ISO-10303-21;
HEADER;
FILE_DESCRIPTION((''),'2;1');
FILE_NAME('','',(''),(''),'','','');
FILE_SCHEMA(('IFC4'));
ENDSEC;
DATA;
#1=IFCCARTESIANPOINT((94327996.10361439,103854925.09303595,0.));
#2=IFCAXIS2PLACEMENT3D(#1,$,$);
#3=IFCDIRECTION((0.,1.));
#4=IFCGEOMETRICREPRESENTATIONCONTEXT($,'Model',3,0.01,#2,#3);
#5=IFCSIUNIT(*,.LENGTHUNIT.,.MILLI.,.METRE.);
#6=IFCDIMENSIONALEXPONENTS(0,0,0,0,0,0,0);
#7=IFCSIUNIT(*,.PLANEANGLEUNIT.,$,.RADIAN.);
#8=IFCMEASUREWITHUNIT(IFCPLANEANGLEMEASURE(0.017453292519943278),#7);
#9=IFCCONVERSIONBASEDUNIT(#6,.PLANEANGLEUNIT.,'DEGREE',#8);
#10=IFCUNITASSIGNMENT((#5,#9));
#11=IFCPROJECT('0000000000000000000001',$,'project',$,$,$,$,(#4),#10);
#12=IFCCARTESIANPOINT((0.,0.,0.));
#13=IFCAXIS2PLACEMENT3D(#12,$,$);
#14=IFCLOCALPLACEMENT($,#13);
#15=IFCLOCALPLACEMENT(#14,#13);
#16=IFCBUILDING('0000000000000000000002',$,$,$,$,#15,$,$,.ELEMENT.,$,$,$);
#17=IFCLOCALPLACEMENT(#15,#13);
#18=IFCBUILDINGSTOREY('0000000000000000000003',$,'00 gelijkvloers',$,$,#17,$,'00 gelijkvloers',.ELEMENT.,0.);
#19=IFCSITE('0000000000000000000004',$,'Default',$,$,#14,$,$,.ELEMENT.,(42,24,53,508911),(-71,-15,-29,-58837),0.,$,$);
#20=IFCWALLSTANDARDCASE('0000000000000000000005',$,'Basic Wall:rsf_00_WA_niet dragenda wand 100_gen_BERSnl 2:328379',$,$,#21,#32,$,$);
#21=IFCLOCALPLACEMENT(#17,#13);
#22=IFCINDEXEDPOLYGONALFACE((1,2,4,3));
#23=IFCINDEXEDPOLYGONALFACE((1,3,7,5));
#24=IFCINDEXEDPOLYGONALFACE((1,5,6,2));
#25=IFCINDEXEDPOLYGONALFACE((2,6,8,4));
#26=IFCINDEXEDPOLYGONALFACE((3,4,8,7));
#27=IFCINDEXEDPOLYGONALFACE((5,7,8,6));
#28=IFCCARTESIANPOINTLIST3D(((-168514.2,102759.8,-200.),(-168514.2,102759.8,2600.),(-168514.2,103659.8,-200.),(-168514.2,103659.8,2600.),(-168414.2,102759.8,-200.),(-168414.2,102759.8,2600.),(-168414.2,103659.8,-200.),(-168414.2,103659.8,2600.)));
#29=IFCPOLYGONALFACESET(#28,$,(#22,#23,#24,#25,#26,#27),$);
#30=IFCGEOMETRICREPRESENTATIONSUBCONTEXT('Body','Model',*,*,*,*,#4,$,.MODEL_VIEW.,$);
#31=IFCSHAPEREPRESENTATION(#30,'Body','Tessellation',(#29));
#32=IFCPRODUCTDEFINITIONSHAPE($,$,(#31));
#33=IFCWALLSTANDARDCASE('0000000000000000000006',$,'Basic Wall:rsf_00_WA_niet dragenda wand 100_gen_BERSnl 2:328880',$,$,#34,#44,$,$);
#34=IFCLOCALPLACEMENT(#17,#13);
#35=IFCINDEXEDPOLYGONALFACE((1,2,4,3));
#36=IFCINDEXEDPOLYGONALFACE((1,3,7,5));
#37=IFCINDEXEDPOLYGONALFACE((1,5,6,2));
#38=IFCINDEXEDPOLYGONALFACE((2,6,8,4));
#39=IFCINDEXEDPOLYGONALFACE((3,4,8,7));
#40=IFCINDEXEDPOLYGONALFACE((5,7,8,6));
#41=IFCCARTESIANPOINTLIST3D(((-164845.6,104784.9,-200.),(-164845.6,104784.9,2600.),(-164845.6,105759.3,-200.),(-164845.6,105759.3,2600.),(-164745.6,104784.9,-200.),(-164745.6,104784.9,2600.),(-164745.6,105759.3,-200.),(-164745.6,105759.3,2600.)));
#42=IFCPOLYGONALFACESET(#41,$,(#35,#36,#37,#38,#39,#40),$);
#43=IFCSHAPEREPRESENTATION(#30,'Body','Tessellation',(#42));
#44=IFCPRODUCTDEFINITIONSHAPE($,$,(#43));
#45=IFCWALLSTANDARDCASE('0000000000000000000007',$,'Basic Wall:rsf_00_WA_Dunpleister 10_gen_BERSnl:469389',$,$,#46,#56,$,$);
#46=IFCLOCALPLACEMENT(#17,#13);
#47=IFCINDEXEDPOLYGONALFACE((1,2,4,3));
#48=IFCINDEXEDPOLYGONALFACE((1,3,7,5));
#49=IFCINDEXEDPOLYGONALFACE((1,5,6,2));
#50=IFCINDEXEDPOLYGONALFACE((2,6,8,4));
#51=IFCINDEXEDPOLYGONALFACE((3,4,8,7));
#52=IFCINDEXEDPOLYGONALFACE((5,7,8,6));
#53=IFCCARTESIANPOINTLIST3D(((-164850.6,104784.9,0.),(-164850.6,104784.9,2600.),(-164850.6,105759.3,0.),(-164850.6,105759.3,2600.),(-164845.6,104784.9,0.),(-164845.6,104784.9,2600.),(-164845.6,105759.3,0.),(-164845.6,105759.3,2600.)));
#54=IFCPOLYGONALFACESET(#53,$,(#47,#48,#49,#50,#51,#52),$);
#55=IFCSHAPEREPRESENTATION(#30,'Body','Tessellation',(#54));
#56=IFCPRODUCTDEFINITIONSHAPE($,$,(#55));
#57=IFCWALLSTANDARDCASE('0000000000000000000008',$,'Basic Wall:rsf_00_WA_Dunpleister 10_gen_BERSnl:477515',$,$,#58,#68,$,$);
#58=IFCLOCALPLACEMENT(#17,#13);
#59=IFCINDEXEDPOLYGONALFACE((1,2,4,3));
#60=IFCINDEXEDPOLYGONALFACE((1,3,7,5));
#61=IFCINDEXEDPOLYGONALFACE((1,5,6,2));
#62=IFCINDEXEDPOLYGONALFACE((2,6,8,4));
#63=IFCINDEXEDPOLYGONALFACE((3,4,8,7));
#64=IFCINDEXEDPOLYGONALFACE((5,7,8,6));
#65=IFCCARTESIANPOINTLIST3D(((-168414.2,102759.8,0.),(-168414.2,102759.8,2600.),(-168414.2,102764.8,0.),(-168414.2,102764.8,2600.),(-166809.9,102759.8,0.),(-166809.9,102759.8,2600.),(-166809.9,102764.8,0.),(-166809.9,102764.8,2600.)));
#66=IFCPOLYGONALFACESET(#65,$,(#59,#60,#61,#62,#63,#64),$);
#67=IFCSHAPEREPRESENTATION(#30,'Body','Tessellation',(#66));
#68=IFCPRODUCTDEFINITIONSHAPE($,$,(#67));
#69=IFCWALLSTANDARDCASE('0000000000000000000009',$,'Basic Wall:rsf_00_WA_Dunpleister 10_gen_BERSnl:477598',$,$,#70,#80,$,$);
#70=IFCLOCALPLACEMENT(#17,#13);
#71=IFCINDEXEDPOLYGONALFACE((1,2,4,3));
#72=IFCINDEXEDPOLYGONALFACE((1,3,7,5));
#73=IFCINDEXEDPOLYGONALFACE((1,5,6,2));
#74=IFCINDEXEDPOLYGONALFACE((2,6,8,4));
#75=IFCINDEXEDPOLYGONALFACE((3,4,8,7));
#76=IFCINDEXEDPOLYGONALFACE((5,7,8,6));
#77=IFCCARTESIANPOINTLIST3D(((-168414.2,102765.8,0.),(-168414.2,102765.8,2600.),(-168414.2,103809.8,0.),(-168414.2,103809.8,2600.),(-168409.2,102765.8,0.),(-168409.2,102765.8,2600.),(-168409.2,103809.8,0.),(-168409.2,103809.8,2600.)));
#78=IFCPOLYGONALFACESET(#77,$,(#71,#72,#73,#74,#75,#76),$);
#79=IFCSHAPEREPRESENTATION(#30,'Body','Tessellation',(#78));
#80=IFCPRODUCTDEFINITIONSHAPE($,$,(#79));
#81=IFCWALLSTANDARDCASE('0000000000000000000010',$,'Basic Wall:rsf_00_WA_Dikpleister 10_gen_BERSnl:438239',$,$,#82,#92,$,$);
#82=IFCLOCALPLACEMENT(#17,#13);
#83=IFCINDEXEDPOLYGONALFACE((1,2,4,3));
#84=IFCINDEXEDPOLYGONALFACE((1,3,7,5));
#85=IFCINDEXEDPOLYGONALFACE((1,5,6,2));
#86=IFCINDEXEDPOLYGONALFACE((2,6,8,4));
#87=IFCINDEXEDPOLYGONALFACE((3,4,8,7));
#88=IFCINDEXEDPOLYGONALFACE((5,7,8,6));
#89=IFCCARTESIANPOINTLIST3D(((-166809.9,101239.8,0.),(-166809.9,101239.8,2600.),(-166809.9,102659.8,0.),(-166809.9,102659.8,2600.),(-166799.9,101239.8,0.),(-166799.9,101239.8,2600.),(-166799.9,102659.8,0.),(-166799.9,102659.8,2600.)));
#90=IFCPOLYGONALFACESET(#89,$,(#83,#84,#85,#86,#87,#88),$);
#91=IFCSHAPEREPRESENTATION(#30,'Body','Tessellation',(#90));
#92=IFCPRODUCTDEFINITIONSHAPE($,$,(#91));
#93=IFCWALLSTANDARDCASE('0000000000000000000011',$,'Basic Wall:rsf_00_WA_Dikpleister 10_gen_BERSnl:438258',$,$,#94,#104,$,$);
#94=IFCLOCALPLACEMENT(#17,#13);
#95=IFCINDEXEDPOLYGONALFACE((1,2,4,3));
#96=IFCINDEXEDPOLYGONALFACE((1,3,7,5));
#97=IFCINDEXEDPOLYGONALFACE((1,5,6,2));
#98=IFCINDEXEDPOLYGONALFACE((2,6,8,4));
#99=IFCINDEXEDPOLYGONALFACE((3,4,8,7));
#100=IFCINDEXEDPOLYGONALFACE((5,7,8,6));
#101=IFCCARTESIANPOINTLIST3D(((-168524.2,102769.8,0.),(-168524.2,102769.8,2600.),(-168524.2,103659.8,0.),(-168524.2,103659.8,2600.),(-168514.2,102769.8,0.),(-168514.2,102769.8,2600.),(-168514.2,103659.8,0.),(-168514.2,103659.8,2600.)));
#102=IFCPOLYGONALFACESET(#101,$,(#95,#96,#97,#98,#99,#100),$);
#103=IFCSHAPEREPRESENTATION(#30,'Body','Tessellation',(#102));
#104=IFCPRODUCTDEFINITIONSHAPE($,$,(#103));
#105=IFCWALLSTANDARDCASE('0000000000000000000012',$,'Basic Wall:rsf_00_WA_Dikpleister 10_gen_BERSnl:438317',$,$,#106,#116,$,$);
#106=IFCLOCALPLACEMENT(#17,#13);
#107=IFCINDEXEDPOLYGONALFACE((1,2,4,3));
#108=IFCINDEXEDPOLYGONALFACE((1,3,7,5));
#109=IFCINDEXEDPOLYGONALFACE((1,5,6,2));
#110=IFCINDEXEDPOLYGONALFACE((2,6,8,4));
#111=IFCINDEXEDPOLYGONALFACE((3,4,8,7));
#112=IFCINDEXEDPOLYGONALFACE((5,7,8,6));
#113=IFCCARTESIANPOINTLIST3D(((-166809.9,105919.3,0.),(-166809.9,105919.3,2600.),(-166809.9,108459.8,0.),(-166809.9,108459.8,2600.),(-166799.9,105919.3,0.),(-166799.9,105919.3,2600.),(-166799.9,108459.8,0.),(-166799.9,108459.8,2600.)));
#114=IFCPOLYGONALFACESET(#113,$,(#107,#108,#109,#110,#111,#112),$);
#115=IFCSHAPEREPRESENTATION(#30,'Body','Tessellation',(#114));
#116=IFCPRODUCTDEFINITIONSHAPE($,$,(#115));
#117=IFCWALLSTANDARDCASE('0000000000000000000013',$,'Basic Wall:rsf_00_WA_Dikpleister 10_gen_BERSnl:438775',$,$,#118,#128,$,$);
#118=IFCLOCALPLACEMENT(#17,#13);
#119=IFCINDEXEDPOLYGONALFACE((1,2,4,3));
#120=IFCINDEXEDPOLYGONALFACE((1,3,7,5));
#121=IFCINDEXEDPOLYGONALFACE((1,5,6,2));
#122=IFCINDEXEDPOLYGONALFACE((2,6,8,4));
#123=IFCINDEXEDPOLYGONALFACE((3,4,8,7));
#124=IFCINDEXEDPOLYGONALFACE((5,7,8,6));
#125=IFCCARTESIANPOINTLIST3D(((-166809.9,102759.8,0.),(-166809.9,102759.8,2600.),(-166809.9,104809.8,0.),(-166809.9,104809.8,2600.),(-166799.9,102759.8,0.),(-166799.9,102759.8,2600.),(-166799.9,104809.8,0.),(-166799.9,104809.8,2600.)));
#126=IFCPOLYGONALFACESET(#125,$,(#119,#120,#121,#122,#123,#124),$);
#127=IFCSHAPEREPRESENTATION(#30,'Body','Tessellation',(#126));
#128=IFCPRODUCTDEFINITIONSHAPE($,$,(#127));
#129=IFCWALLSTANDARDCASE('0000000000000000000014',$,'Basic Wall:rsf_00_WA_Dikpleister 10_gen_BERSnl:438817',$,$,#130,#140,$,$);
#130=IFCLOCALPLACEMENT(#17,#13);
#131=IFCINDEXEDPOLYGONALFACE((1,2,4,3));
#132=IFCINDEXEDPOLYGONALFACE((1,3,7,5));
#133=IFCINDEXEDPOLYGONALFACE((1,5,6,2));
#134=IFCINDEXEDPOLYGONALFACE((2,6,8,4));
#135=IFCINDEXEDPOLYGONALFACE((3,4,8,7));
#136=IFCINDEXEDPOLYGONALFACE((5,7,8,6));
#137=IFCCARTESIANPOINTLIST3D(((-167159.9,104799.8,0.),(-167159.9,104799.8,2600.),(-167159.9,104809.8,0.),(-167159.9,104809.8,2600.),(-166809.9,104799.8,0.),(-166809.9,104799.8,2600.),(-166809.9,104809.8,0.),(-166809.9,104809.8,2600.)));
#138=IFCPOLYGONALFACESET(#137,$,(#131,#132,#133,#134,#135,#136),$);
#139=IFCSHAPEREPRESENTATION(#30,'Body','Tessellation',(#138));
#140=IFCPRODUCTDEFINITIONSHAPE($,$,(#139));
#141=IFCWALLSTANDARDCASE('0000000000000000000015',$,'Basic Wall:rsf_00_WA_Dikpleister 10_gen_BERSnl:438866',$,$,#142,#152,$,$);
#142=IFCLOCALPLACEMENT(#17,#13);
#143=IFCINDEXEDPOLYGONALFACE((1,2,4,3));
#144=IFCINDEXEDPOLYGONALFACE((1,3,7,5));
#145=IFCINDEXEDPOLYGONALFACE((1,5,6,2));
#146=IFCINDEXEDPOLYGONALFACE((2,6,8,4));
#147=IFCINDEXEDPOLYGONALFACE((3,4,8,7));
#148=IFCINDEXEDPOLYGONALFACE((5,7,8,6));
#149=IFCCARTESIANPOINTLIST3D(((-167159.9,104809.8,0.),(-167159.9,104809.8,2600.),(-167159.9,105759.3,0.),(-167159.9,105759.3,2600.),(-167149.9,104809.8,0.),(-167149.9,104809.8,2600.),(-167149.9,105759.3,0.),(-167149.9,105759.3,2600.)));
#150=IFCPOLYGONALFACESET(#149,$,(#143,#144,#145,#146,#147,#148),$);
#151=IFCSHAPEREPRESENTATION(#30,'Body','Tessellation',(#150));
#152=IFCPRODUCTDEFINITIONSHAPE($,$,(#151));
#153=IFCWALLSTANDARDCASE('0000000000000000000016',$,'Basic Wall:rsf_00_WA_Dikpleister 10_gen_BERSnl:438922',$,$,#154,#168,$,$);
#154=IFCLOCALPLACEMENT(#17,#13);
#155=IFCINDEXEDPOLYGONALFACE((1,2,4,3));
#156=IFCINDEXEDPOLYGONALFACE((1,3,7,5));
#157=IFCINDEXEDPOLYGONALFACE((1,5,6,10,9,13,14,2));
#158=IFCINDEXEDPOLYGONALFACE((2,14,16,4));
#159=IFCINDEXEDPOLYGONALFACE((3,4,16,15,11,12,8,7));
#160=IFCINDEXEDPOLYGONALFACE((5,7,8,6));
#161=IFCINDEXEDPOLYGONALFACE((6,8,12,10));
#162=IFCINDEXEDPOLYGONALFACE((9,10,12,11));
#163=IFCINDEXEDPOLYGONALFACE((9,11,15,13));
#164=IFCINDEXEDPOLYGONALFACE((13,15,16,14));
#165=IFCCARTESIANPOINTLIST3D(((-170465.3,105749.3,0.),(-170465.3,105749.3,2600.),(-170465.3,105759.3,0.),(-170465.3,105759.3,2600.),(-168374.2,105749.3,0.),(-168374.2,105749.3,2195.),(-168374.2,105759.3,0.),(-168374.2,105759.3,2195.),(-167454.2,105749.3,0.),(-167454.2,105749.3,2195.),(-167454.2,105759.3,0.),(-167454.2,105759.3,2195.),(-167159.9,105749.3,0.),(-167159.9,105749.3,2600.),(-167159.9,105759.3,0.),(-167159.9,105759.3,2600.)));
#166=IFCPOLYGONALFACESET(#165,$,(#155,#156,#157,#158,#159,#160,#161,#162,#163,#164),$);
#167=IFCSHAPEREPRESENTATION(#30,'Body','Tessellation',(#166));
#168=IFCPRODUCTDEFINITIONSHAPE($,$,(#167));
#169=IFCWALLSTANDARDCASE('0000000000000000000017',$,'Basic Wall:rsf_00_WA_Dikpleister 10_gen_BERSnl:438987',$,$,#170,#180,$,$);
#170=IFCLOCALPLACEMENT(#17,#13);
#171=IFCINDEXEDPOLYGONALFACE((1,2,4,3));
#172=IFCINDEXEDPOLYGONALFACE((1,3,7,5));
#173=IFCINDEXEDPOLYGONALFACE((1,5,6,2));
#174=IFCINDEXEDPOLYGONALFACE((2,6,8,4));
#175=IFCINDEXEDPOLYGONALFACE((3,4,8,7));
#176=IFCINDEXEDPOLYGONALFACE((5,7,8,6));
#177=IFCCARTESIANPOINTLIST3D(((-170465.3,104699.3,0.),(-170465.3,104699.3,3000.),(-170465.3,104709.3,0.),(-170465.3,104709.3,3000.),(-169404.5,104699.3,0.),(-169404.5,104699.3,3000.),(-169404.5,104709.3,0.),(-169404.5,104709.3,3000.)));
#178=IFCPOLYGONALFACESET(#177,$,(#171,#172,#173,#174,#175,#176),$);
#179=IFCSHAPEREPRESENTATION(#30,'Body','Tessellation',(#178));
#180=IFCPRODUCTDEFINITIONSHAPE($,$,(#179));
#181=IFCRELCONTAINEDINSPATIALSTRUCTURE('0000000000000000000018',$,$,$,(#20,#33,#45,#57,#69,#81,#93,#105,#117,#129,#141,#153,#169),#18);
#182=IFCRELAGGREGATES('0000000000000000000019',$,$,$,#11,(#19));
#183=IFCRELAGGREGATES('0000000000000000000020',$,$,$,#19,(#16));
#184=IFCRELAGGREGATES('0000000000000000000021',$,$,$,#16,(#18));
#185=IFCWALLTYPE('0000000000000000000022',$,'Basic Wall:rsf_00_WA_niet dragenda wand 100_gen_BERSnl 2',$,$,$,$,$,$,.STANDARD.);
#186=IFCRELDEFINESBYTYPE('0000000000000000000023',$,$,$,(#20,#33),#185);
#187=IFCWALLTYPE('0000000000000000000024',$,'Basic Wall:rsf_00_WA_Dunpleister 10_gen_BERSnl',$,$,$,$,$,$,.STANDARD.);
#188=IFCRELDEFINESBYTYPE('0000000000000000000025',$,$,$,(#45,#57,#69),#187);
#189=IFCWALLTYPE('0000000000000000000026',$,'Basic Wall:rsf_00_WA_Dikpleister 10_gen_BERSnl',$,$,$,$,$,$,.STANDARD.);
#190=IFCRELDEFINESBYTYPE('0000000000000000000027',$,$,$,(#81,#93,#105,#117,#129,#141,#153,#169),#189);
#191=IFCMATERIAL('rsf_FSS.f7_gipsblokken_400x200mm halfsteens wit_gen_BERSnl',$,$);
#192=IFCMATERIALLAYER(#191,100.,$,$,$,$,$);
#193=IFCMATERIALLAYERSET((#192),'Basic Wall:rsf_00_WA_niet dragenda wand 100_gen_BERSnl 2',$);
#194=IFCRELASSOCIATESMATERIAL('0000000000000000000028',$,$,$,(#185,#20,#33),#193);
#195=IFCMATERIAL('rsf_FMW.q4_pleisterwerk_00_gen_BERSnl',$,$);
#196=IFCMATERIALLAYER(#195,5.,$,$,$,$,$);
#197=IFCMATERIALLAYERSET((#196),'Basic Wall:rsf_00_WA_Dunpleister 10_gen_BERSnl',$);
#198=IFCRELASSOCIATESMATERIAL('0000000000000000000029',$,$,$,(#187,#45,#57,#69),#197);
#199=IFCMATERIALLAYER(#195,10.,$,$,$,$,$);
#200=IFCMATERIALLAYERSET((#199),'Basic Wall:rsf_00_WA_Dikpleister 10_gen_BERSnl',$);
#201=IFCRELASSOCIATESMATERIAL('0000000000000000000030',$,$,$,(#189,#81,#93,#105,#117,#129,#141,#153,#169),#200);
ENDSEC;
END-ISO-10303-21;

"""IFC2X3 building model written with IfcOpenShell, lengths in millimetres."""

from ifc_helpers import new_model, entity, si_unit, converted_unit, direction, frame, frame_2d, origin, place, context, subcontext, project, spatial, polyline, rectangle, outline, extrude, material, layer, layer_set, layer_usage, type_object, element, save


model = new_model("IFC2X3")

# Units and contexts
model_context = context("Model", 3, precision=0.01, world=frame((94327996.10361439, 103854925.09303595, 0.0)), true_north=direction((0.0, 1.0)))
body_context = subcontext(model_context, "Body", "Model", "MODEL_VIEW")
ifc_project = project(units=[si_unit("LENGTHUNIT", "METRE", prefix="MILLI"), converted_unit("PLANEANGLEUNIT", "DEGREE", entity("IfcPlaneAngleMeasure", 0.017453292519943278), si_unit("PLANEANGLEUNIT", "RADIAN"), dimensions=[0, 0, 0, 0, 0, 0, 0])], contexts=[model_context])

# Site, building, storey
site_placement = place(None, origin())
site = spatial("IfcSite", under=ifc_project, at=site_placement, Name="Default", CompositionType="ELEMENT", RefLatitude=(42, 24, 53, 508911), RefLongitude=(-71, -15, -29, -58837), RefElevation=0.0)
building_placement = place(site_placement, origin())
building = spatial("IfcBuilding", under=site, at=building_placement, CompositionType="ELEMENT")
storey_placement = place(building_placement, origin())
storey = spatial("IfcBuildingStorey", under=building, at=storey_placement, Name="00 gelijkvloers", LongName="00 gelijkvloers", CompositionType="ELEMENT", Elevation=0.0)

# Walls
ifc_material_1 = material(Name="rsf_FSS.f7_gipsblokken_400x200mm halfsteens wit_gen_BERSnl")
ifc_layer_1 = layer(ifc_material_1, 100.0)
ifc_layer_set_1 = layer_set([ifc_layer_1], Name="Basic Wall:rsf_00_WA_niet dragenda wand 100_gen_BERSnl 2")
ifc_layer_usage_1 = layer_usage(ifc_layer_set_1, "AXIS2", "NEGATIVE", 50.0)
wall_type_1 = type_object("IfcWallType", Name="Basic Wall:rsf_00_WA_niet dragenda wand 100_gen_BERSnl 2", PredefinedType="STANDARD", material=ifc_layer_set_1)
wall_1_placement = place(storey_placement, frame((-168464.2, 102759.8, -200.0), z_axis=(0.0, 0.0, 1.0), x_axis=(0.0, 1.0, 0.0)))
element("IfcWallStandardCase", 1, at=wall_1_placement, inside=storey, type_object=wall_type_1, material=ifc_layer_usage_1, Name="Basic Wall:rsf_00_WA_niet dragenda wand 100_gen_BERSnl 2:328379", context=body_context, shape_type="SweptSolid", body=[
    extrude(rectangle(XDim=900.0, YDim=100.0, at=frame_2d((450.0, 0.0), x_axis=(-1.0, 0.0))), origin(), (0.0, 0.0, 1.0), 2800.0),
])
ifc_layer_usage_2 = layer_usage(ifc_layer_set_1, "AXIS2", "NEGATIVE", 50.0)
wall_2_placement = place(storey_placement, frame((-164795.6, 105759.3, -200.0), z_axis=(0.0, 0.0, 1.0), x_axis=(0.0, -1.0, 0.0)))
element("IfcWallStandardCase", 2, at=wall_2_placement, inside=storey, type_object=wall_type_1, material=ifc_layer_usage_2, Name="Basic Wall:rsf_00_WA_niet dragenda wand 100_gen_BERSnl 2:328880", context=body_context, shape_type="SweptSolid", body=[
    extrude(rectangle(XDim=974.4, YDim=100.0, at=frame_2d((487.2, 0.0), x_axis=(-1.0, 0.0))), origin(), (0.0, 0.0, 1.0), 2800.0),
])
ifc_material_2 = material(Name="rsf_FMW.q4_pleisterwerk_00_gen_BERSnl")
ifc_layer_2 = layer(ifc_material_2, 5.0)
ifc_layer_set_2 = layer_set([ifc_layer_2], Name="Basic Wall:rsf_00_WA_Dunpleister 10_gen_BERSnl")
ifc_layer_usage_3 = layer_usage(ifc_layer_set_2, "AXIS2", "NEGATIVE", 2.5)
wall_type_2 = type_object("IfcWallType", Name="Basic Wall:rsf_00_WA_Dunpleister 10_gen_BERSnl", PredefinedType="STANDARD", material=ifc_layer_set_2)
wall_3_placement = place(storey_placement, frame((-164848.1, 104784.9, 0.0), z_axis=(0.0, 0.0, 1.0), x_axis=(0.0, 1.0, 0.0)))
element("IfcWallStandardCase", 3, at=wall_3_placement, inside=storey, type_object=wall_type_2, material=ifc_layer_usage_3, Name="Basic Wall:rsf_00_WA_Dunpleister 10_gen_BERSnl:469389", context=body_context, shape_type="SweptSolid", body=[
    extrude(rectangle(XDim=974.4, YDim=5.0, at=frame_2d((487.2, 0.0), x_axis=(-1.0, 0.0))), origin(), (0.0, 0.0, 1.0), 2600.0),
])
ifc_layer_usage_4 = layer_usage(ifc_layer_set_2, "AXIS2", "NEGATIVE", 2.5)
wall_4_placement = place(storey_placement, frame((-168414.2, 102762.3, 0.0)))
element("IfcWallStandardCase", 4, at=wall_4_placement, inside=storey, type_object=wall_type_2, material=ifc_layer_usage_4, Name="Basic Wall:rsf_00_WA_Dunpleister 10_gen_BERSnl:477515", context=body_context, shape_type="SweptSolid", body=[
    extrude(rectangle(XDim=1604.3, YDim=5.0, at=frame_2d((802.1, 0.0), x_axis=(-1.0, 0.0))), origin(), (0.0, 0.0, 1.0), 2600.0),
])
ifc_layer_usage_5 = layer_usage(ifc_layer_set_2, "AXIS2", "POSITIVE", -2.5)
wall_5_placement = place(storey_placement, frame((-168411.7, 102765.8, 0.0), z_axis=(0.0, 0.0, 1.0), x_axis=(0.0, 1.0, 0.0)))
element("IfcWallStandardCase", 5, at=wall_5_placement, inside=storey, type_object=wall_type_2, material=ifc_layer_usage_5, Name="Basic Wall:rsf_00_WA_Dunpleister 10_gen_BERSnl:477598", context=body_context, shape_type="SweptSolid", body=[
    extrude(rectangle(XDim=1044.0, YDim=5.0, at=frame_2d((522.0, 0.0), x_axis=(-1.0, 0.0))), origin(), (0.0, 0.0, 1.0), 2600.0),
])
ifc_layer_3 = layer(ifc_material_2, 10.0)
ifc_layer_set_3 = layer_set([ifc_layer_3], Name="Basic Wall:rsf_00_WA_Dikpleister 10_gen_BERSnl")
ifc_layer_usage_6 = layer_usage(ifc_layer_set_3, "AXIS2", "POSITIVE", -5.0)
wall_type_3 = type_object("IfcWallType", Name="Basic Wall:rsf_00_WA_Dikpleister 10_gen_BERSnl", PredefinedType="STANDARD", material=ifc_layer_set_3)
wall_6_placement = place(storey_placement, frame((-166804.9, 102659.8, 0.0), z_axis=(0.0, 0.0, 1.0), x_axis=(0.0, -1.0, 0.0)))
element("IfcWallStandardCase", 6, at=wall_6_placement, inside=storey, type_object=wall_type_3, material=ifc_layer_usage_6, Name="Basic Wall:rsf_00_WA_Dikpleister 10_gen_BERSnl:438239", context=body_context, shape_type="SweptSolid", body=[
    extrude(rectangle(XDim=1420.0, YDim=10.0, at=frame_2d((710.0, 0.0), x_axis=(-1.0, 0.0))), origin(), (0.0, 0.0, 1.0), 2600.0),
])

# Wall
ifc_layer_usage_7 = layer_usage(ifc_layer_set_3, "AXIS2", "POSITIVE", -5.0)
wall_7_placement = place(storey_placement, frame((-168519.2, 103659.8, 0.0), z_axis=(0.0, 0.0, 1.0), x_axis=(0.0, -1.0, 0.0)))
element("IfcWallStandardCase", 7, at=wall_7_placement, inside=storey, type_object=wall_type_3, material=ifc_layer_usage_7, Name="Basic Wall:rsf_00_WA_Dikpleister 10_gen_BERSnl:438258", context=body_context, shape_type="SweptSolid", body=[
    extrude(rectangle(XDim=890.0, YDim=10.0, at=frame_2d((445.0, 0.0), x_axis=(-1.0, 0.0))), origin(), (0.0, 0.0, 1.0), 2600.0),
])

# Walls
ifc_layer_usage_8 = layer_usage(ifc_layer_set_3, "AXIS2", "POSITIVE", -5.0)
wall_8_placement = place(storey_placement, frame((-166804.9, 108459.8, 0.0), z_axis=(0.0, 0.0, 1.0), x_axis=(0.0, -1.0, 0.0)))
element("IfcWallStandardCase", 8, at=wall_8_placement, inside=storey, type_object=wall_type_3, material=ifc_layer_usage_8, Name="Basic Wall:rsf_00_WA_Dikpleister 10_gen_BERSnl:438317", context=body_context, shape_type="SweptSolid", body=[
    extrude(rectangle(XDim=2540.5, YDim=10.0, at=frame_2d((1270.2, 0.0), x_axis=(-1.0, 0.0))), origin(), (0.0, 0.0, 1.0), 2600.0),
])
ifc_layer_usage_9 = layer_usage(ifc_layer_set_3, "AXIS2", "NEGATIVE", 5.0)
wall_9_placement = place(storey_placement, frame((-166804.9, 102759.8, 0.0), z_axis=(0.0, 0.0, 1.0), x_axis=(0.0, 1.0, 0.0)))
element("IfcWallStandardCase", 9, at=wall_9_placement, inside=storey, type_object=wall_type_3, material=ifc_layer_usage_9, Name="Basic Wall:rsf_00_WA_Dikpleister 10_gen_BERSnl:438775", context=body_context, shape_type="SweptSolid", body=[
    extrude(rectangle(XDim=2050.0, YDim=10.0, at=frame_2d((1025.0, 0.0), x_axis=(-1.0, 0.0))), origin(), (0.0, 0.0, 1.0), 2600.0),
])
ifc_layer_usage_10 = layer_usage(ifc_layer_set_3, "AXIS2", "NEGATIVE", 5.0)
wall_10_placement = place(storey_placement, frame((-166809.9, 104804.8, 0.0), z_axis=(0.0, 0.0, 1.0), x_axis=(-1.0, 0.0, 0.0)))
element("IfcWallStandardCase", 10, at=wall_10_placement, inside=storey, type_object=wall_type_3, material=ifc_layer_usage_10, Name="Basic Wall:rsf_00_WA_Dikpleister 10_gen_BERSnl:438817", context=body_context, shape_type="SweptSolid", body=[
    extrude(rectangle(XDim=350.0, YDim=10.0, at=frame_2d((175.0, 0.0), x_axis=(-1.0, 0.0))), origin(), (0.0, 0.0, 1.0), 2600.0),
])
ifc_layer_usage_11 = layer_usage(ifc_layer_set_3, "AXIS2", "NEGATIVE", 5.0)
wall_11_placement = place(storey_placement, frame((-167154.9, 104809.8, 0.0), z_axis=(0.0, 0.0, 1.0), x_axis=(0.0, 1.0, 0.0)))
element("IfcWallStandardCase", 11, at=wall_11_placement, inside=storey, type_object=wall_type_3, material=ifc_layer_usage_11, Name="Basic Wall:rsf_00_WA_Dikpleister 10_gen_BERSnl:438866", context=body_context, shape_type="SweptSolid", body=[
    extrude(rectangle(XDim=949.5, YDim=10.0, at=frame_2d((474.8, 0.0), x_axis=(-1.0, 0.0))), origin(), (0.0, 0.0, 1.0), 2600.0),
])

# Wall, opening
ifc_layer_usage_12 = layer_usage(ifc_layer_set_3, "AXIS2", "NEGATIVE", 5.0)
wall_12_placement = place(storey_placement, frame((-167159.9, 105754.3, 0.0), z_axis=(0.0, 0.0, 1.0), x_axis=(-1.0, 0.0, 0.0)))
wall_12 = element("IfcWallStandardCase", 12, at=wall_12_placement, inside=storey, type_object=wall_type_3, material=ifc_layer_usage_12, Name="Basic Wall:rsf_00_WA_Dikpleister 10_gen_BERSnl:438922", context=body_context, shape_type="SweptSolid", body=[
    extrude(outline(polyline([(0.0, -5.0), (3305.5, -5.0), (3305.5, 5.0), (0.0, 5.0), (0.0, -5.0)])), origin(), (0.0, 0.0, 1.0), 2600.0),
])
opening_1_placement = place(wall_12_placement, frame((294.3, -5.0, -200.0)))
element("IfcOpeningElement", 13, at=opening_1_placement, cuts=wall_12, ObjectType="Opening", context=body_context, shape_type="SweptSolid", body=[
    extrude(rectangle(XDim=2395.0, YDim=920.0, at=frame_2d((1197.5, 460.0), x_axis=(-1.0, 0.0))), frame((0.0, 0.0, 0.0), z_axis=(0.0, 1.0, 0.0), x_axis=(0.0, 0.0, 1.0)), (0.0, 0.0, 1.0), 10.0),
])

# Wall
ifc_layer_usage_13 = layer_usage(ifc_layer_set_3, "AXIS2", "NEGATIVE", 5.0)
wall_13_placement = place(storey_placement, frame((-169404.5, 104704.3, 0.0), z_axis=(0.0, 0.0, 1.0), x_axis=(-1.0, 0.0, 0.0)))
element("IfcWallStandardCase", 14, at=wall_13_placement, inside=storey, type_object=wall_type_3, material=ifc_layer_usage_13, Name="Basic Wall:rsf_00_WA_Dikpleister 10_gen_BERSnl:438987", context=body_context, shape_type="SweptSolid", body=[
    extrude(rectangle(XDim=1060.8, YDim=10.0, at=frame_2d((530.4, 0.0), x_axis=(-1.0, 0.0))), origin(), (0.0, 0.0, 1.0), 3000.0),
])

save(model, "model.ifc")
